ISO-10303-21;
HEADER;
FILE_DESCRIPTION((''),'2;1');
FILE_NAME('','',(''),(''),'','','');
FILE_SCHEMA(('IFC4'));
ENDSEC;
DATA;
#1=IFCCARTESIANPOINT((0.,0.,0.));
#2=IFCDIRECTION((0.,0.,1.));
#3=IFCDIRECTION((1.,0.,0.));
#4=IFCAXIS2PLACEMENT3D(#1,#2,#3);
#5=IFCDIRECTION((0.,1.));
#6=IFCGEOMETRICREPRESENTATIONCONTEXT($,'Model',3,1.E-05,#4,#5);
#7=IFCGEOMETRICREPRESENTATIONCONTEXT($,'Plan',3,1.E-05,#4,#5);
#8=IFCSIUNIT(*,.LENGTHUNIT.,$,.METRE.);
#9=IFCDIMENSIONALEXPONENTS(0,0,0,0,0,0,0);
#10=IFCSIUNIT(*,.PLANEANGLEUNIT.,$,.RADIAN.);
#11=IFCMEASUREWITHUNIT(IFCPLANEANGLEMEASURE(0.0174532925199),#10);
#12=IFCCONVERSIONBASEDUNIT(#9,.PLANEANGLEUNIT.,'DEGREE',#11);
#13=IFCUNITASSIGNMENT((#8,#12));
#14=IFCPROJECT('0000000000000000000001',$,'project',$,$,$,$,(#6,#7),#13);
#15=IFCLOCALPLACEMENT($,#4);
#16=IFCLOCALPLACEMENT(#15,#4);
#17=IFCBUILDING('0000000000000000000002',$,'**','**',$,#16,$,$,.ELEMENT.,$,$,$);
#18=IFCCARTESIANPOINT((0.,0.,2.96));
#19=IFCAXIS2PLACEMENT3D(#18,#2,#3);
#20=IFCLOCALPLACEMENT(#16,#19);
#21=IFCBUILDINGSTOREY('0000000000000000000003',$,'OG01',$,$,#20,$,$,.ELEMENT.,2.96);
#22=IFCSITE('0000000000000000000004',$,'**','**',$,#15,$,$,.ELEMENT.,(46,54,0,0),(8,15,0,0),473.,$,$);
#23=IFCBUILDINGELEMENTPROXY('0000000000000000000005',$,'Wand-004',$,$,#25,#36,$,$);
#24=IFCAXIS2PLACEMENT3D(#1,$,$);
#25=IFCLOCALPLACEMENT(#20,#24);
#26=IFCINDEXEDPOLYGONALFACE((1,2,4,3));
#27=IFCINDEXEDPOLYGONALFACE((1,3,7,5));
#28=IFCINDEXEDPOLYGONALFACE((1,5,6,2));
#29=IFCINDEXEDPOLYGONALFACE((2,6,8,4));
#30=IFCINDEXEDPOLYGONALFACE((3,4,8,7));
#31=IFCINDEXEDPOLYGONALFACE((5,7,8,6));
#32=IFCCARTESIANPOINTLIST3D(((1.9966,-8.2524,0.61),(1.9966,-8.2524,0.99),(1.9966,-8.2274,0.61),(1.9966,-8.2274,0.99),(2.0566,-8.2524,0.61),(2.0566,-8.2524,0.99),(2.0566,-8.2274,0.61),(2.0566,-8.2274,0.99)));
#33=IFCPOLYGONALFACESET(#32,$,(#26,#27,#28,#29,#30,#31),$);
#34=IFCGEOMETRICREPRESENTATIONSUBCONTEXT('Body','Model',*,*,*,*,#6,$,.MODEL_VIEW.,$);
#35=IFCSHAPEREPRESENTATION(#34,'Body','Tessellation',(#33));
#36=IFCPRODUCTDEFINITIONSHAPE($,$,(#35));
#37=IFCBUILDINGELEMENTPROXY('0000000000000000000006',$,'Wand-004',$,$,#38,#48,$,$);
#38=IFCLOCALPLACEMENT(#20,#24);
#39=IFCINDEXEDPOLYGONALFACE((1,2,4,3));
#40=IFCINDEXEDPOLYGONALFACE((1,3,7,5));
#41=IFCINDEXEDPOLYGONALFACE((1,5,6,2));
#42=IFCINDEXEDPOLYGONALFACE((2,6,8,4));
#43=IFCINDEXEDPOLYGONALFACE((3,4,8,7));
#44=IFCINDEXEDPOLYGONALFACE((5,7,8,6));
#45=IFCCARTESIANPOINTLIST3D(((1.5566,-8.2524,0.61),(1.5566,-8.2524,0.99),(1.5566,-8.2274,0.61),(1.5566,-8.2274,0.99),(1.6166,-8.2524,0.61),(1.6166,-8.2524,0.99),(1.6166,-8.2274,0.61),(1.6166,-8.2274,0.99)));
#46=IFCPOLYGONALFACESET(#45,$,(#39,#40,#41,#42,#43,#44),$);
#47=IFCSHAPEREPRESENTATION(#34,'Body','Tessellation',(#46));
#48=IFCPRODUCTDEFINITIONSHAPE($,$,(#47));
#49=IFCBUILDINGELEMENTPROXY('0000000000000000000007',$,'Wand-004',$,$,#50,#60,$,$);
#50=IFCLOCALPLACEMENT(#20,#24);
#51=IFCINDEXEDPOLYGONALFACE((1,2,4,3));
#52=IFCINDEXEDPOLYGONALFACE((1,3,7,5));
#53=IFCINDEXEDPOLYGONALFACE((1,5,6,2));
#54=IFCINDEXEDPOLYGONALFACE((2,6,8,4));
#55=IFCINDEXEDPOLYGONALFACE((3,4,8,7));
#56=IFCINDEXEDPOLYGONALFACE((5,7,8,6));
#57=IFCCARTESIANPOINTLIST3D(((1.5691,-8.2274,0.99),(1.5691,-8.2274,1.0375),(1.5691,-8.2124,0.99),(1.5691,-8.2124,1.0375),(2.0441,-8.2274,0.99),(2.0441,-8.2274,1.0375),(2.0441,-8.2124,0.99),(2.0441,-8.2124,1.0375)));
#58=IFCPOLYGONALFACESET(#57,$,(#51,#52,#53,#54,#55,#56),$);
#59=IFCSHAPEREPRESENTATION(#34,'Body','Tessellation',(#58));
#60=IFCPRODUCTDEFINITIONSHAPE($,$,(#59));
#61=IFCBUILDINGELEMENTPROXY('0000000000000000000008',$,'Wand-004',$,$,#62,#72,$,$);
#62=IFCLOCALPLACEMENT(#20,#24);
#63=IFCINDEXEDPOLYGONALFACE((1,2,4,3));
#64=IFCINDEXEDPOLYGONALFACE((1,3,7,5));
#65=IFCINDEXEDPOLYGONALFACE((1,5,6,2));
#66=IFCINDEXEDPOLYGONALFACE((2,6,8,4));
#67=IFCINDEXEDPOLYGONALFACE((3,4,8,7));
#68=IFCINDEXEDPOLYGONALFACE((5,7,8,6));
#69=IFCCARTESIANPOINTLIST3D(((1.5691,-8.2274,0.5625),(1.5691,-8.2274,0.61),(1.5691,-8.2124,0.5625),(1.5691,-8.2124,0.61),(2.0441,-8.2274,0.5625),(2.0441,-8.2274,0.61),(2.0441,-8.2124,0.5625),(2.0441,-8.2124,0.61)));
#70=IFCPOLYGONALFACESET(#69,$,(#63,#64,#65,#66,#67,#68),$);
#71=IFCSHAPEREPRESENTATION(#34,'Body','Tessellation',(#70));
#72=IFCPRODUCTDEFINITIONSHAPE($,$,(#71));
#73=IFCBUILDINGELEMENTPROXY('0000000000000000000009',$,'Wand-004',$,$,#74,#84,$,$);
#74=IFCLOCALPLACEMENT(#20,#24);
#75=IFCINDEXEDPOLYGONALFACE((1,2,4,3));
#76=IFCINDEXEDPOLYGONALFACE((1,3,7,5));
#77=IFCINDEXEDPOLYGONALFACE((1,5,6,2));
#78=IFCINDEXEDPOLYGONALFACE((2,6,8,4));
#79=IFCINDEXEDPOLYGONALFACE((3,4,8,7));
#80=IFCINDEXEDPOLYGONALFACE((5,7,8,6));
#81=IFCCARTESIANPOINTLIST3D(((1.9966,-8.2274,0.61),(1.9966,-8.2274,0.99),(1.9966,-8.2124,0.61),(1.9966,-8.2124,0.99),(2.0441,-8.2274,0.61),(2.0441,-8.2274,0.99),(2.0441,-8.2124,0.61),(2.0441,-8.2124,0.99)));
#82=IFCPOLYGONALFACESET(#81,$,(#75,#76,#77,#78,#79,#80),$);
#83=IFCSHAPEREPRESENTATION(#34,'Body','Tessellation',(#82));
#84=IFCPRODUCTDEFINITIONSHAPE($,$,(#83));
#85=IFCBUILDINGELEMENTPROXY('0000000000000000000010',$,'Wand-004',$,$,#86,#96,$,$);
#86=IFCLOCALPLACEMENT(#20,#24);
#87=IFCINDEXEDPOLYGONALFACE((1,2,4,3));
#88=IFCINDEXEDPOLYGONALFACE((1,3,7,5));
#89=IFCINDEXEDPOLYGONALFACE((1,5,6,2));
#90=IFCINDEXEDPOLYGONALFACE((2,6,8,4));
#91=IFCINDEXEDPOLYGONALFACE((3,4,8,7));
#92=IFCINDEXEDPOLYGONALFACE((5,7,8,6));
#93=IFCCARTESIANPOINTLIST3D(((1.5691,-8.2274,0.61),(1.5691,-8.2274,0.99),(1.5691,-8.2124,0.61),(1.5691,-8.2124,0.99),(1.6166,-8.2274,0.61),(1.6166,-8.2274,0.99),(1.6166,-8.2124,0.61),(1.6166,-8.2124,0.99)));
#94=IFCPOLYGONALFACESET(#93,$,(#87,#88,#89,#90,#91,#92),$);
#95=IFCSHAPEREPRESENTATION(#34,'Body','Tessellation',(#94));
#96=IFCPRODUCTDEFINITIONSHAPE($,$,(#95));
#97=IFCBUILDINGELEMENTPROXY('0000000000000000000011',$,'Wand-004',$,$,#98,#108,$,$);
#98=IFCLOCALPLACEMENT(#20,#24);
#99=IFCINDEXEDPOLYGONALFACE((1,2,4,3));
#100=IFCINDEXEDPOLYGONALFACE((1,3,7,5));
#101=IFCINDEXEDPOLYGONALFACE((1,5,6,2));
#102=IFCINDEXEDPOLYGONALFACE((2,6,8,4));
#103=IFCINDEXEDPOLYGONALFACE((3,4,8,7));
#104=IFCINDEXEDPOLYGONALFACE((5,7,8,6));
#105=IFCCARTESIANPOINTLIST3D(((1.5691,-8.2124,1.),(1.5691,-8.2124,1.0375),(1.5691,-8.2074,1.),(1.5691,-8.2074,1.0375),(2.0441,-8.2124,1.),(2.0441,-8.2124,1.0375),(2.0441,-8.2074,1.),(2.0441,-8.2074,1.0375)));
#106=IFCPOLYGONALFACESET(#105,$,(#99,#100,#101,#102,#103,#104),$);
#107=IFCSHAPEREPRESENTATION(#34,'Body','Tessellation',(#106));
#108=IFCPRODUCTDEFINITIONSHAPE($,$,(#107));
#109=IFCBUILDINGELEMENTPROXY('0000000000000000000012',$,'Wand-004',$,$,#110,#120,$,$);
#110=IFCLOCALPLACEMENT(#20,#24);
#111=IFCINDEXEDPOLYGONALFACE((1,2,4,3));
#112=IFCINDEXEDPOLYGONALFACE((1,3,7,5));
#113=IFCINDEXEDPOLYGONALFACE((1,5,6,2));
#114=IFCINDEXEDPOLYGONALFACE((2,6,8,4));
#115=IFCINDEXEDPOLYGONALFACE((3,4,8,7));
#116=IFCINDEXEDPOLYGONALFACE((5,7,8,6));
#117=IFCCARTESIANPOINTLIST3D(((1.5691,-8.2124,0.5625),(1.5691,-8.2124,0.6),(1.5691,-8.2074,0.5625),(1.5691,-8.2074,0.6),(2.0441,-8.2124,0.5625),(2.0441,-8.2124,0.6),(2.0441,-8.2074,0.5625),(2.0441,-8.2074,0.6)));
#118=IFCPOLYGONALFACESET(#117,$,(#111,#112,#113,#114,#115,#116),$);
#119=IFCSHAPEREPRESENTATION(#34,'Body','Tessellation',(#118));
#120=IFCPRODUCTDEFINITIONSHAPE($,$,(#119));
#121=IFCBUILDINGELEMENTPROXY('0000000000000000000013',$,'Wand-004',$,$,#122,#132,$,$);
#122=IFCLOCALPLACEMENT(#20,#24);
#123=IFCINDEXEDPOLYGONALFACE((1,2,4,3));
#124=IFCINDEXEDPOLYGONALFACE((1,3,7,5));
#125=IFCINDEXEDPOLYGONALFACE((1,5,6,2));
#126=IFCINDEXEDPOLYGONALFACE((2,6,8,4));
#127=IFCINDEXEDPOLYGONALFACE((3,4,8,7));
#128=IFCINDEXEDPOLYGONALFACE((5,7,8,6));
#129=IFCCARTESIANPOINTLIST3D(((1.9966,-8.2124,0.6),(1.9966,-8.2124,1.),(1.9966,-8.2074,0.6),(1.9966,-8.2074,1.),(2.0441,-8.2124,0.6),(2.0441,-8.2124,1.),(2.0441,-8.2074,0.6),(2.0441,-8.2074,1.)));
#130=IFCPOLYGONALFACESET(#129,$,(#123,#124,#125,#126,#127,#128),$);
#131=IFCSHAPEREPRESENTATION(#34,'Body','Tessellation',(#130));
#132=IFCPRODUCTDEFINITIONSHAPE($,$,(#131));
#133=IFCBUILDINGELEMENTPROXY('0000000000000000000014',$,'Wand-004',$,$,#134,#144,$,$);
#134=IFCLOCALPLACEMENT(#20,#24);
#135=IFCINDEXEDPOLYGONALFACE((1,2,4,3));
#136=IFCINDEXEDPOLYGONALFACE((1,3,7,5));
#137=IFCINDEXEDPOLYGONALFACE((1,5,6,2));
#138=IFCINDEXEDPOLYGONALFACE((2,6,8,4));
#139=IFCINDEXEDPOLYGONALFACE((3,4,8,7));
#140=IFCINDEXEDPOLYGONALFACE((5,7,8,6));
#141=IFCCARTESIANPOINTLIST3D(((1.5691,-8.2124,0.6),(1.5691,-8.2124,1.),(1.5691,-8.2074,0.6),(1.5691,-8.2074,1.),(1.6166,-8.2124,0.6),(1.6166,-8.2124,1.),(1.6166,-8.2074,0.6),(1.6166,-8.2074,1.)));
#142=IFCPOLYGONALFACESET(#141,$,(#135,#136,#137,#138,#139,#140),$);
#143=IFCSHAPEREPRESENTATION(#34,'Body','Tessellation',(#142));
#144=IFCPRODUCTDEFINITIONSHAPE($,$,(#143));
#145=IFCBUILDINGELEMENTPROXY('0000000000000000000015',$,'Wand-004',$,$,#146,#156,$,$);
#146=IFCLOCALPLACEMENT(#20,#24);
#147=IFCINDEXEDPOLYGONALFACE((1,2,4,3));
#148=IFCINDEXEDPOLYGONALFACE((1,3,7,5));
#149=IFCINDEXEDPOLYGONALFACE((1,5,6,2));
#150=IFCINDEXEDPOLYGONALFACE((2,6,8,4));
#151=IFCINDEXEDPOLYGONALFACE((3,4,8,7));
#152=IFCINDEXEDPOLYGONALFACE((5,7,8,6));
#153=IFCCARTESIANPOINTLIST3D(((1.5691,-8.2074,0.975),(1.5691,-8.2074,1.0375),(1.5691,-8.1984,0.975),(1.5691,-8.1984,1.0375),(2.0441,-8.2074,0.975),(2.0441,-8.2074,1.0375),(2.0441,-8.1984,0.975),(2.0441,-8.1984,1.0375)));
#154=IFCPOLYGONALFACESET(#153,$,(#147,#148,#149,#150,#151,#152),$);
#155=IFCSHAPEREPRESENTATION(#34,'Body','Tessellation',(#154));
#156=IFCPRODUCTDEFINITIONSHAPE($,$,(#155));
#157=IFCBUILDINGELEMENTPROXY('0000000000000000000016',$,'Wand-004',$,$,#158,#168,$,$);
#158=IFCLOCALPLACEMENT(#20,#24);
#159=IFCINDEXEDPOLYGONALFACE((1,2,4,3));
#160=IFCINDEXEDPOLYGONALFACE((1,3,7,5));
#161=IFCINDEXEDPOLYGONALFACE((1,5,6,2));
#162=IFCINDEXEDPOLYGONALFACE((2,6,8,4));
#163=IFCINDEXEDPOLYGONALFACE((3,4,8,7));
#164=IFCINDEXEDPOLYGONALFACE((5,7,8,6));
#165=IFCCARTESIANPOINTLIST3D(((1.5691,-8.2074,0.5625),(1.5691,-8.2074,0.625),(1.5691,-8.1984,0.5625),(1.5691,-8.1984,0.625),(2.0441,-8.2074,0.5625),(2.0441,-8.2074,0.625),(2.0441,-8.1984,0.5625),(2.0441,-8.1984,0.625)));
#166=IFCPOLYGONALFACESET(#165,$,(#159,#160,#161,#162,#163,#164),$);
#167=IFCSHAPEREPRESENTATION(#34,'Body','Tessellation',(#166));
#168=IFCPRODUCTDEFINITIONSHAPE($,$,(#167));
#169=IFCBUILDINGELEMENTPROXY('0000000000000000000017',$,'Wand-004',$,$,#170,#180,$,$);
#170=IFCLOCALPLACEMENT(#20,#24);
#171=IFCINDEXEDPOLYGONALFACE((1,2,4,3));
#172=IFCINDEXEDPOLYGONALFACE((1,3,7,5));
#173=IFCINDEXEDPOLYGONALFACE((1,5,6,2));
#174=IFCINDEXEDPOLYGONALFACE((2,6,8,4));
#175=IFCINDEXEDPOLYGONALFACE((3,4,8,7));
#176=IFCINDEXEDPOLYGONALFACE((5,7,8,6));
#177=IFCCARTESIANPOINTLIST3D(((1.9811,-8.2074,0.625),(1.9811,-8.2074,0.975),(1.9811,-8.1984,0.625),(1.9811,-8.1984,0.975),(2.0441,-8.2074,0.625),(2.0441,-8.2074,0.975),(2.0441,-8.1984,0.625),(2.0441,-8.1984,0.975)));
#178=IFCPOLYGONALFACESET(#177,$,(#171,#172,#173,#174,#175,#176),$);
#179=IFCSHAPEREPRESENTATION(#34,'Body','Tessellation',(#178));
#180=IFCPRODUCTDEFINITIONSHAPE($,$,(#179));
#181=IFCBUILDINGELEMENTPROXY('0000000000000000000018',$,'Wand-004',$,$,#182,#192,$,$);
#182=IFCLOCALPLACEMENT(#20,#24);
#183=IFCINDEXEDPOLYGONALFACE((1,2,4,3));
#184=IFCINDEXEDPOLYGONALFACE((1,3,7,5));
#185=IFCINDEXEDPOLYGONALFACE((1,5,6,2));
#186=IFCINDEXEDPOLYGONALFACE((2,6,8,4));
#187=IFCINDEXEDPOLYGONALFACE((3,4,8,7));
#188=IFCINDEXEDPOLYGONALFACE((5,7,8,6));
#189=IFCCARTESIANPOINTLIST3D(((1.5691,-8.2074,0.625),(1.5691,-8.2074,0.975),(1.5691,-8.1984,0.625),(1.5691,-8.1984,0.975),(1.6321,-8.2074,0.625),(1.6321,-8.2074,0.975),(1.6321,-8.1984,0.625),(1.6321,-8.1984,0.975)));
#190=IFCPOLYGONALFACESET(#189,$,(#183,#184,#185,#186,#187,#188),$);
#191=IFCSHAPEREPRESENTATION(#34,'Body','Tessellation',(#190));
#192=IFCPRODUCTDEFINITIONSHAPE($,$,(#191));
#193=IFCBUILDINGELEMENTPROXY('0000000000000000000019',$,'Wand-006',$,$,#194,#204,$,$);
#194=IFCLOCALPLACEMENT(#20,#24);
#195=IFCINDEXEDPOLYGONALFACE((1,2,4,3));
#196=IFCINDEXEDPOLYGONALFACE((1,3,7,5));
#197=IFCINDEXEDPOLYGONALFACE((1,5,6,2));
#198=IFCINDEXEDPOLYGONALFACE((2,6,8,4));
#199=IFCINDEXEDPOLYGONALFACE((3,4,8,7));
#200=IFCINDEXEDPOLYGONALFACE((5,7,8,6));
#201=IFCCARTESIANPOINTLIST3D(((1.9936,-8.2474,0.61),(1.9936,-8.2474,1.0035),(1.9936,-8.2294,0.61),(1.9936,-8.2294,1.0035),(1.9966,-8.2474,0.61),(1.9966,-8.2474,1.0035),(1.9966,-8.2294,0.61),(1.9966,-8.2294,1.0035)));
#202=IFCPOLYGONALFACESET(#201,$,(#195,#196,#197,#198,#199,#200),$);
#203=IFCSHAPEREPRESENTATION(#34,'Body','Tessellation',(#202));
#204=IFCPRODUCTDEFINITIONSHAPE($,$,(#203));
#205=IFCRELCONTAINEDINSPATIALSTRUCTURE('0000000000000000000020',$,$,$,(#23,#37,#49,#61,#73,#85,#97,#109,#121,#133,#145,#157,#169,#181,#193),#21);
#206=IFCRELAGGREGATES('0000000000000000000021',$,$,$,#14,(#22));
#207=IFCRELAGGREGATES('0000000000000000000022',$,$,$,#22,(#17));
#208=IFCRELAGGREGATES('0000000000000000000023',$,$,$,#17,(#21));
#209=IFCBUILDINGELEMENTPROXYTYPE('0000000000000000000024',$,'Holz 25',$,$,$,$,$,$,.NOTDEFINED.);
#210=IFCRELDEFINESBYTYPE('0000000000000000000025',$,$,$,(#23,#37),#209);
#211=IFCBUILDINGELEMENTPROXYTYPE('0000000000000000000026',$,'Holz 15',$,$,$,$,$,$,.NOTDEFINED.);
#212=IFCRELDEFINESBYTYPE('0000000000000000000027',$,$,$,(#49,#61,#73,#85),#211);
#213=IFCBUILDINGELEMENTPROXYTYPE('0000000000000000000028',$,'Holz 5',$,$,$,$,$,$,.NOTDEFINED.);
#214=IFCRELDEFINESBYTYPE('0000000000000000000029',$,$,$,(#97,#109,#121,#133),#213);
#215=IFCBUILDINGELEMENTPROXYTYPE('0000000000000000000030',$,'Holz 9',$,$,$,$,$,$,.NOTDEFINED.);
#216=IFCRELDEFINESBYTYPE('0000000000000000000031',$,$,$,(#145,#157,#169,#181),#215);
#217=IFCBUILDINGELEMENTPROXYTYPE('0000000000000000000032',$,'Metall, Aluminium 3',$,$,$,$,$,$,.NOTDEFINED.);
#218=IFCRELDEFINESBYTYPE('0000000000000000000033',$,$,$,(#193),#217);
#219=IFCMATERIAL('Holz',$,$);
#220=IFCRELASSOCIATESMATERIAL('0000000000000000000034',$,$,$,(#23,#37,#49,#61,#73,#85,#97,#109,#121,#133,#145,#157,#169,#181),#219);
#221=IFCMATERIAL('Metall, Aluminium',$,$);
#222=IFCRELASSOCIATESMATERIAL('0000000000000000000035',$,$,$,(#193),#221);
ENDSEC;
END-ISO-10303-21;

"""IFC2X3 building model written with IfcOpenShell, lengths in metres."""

from ifc_helpers import new_model, entity, si_unit, converted_unit, direction, frame, origin_with_axes, place, context, subcontext, project, spatial, polyline, outline, extrude, material, type_object, element, save


model = new_model("IFC2X3")

# Units and contexts
model_context = context("Model", 3, precision=1e-05, world=origin_with_axes(), true_north=direction((0.0, 1.0)))
plan_context = context("Plan", 3, precision=1e-05, world=origin_with_axes(), true_north=direction((0.0, 1.0)))
body_context = subcontext(model_context, "Body", "Model", "MODEL_VIEW")
ifc_project = project(units=[si_unit("LENGTHUNIT", "METRE"), converted_unit("PLANEANGLEUNIT", "DEGREE", entity("IfcPlaneAngleMeasure", 0.0174532925199), si_unit("PLANEANGLEUNIT", "RADIAN"), dimensions=[0, 0, 0, 0, 0, 0, 0])], contexts=[model_context, plan_context])

# Site, building, storey
site_placement = place(None, origin_with_axes())
site = spatial("IfcSite", under=ifc_project, at=site_placement, Name="**", Description="**", CompositionType="ELEMENT", RefLatitude=(46, 54, 0, 0), RefLongitude=(8, 15, 0, 0), RefElevation=473.0)
building_placement = place(site_placement, origin_with_axes())
building = spatial("IfcBuilding", under=site, at=building_placement, Name="**", Description="**", CompositionType="ELEMENT")
storey_placement = place(building_placement, frame((0.0, 0.0, 2.96), z_axis=(0.0, 0.0, 1.0), x_axis=(1.0, 0.0, 0.0)))
storey = spatial("IfcBuildingStorey", under=building, at=storey_placement, Name="OG01", CompositionType="ELEMENT", Elevation=2.96)

# Building element proxies
ifc_material_1 = material(Name="Holz")
building_element_proxy_type_1 = type_object("IfcBuildingElementProxyType", Name="Holz 25", PredefinedType="NOTDEFINED")
for number, where, z_axis, x_axis, name in (
    (1, (1.9966, -8.2524, 0.61), (0.0, 0.0, 1.0), (1.0, 0.0, 0.0), "Wand-004"),
    (2, (1.5566, -8.2524, 0.61), (0.0, 0.0, 1.0), (1.0, 0.0, 0.0), "Wand-004"),
):
    element("IfcBuildingElementProxy", number, at=place(storey_placement, frame(where, z_axis=z_axis, x_axis=x_axis)), inside=storey, type_object=building_element_proxy_type_1, material=ifc_material_1, Name=name, context=body_context, shape_type="SweptSolid", body=[
        extrude(outline(polyline([(0.0, 0.0), (0.06, 0.0), (0.06, 0.025), (0.0, 0.025), (0.0, 0.0)])), origin_with_axes(), (0.0, 0.0, 1.0), 0.38),
    ])
building_element_proxy_type_2 = type_object("IfcBuildingElementProxyType", Name="Holz 15", PredefinedType="NOTDEFINED")
for number, where, z_axis, x_axis, name in (
    (3, (2.0441, -8.2124, 0.99), (0.0, 0.0, 1.0), (-1.0, 0.0, 0.0), "Wand-004"),
    (4, (2.0441, -8.2124, 0.5625), (0.0, 0.0, 1.0), (-1.0, 0.0, 0.0), "Wand-004"),
):
    element("IfcBuildingElementProxy", number, at=place(storey_placement, frame(where, z_axis=z_axis, x_axis=x_axis)), inside=storey, type_object=building_element_proxy_type_2, material=ifc_material_1, Name=name, context=body_context, shape_type="SweptSolid", body=[
        extrude(outline(polyline([(0.0, 0.0), (0.475, 0.0), (0.475, 0.015), (0.0, 0.015), (0.0, 0.0)])), origin_with_axes(), (0.0, 0.0, 1.0), 0.0475),
    ])
for number, where, z_axis, x_axis, name in (
    (5, (1.9966, -8.2274, 0.61), (0.0, 0.0, 1.0), (1.0, 0.0, 0.0), "Wand-004"),
    (6, (1.5691, -8.2274, 0.61), (0.0, 0.0, 1.0), (1.0, 0.0, 0.0), "Wand-004"),
):
    element("IfcBuildingElementProxy", number, at=place(storey_placement, frame(where, z_axis=z_axis, x_axis=x_axis)), inside=storey, type_object=building_element_proxy_type_2, material=ifc_material_1, Name=name, context=body_context, shape_type="SweptSolid", body=[
        extrude(outline(polyline([(0.0, 0.0), (0.0475, 0.0), (0.0475, 0.015), (0.0, 0.015), (0.0, 0.0)])), origin_with_axes(), (0.0, 0.0, 1.0), 0.38),
    ])
building_element_proxy_type_3 = type_object("IfcBuildingElementProxyType", Name="Holz 5", PredefinedType="NOTDEFINED")
for number, where, z_axis, x_axis, name in (
    (7, (2.0441, -8.2124, 1.0), (0.0, 0.0, 1.0), (-1.0, 0.0, 0.0), "Wand-004"),
    (8, (2.0441, -8.2124, 0.5625), (0.0, 0.0, 1.0), (-1.0, 0.0, 0.0), "Wand-004"),
):
    element("IfcBuildingElementProxy", number, at=place(storey_placement, frame(where, z_axis=z_axis, x_axis=x_axis)), inside=storey, type_object=building_element_proxy_type_3, material=ifc_material_1, Name=name, context=body_context, shape_type="SweptSolid", body=[
        extrude(outline(polyline([(0.0, -0.005), (0.475, -0.005), (0.475, 0.0), (0.0, 0.0), (0.0, -0.005)])), origin_with_axes(), (0.0, 0.0, 1.0), 0.0375),
    ])
for number, where, z_axis, x_axis, name in (
    (9, (1.9966, -8.2124, 0.6), (0.0, 0.0, 1.0), (1.0, 0.0, 0.0), "Wand-004"),
    (10, (1.5691, -8.2124, 0.6), (0.0, 0.0, 1.0), (1.0, 0.0, 0.0), "Wand-004"),
):
    element("IfcBuildingElementProxy", number, at=place(storey_placement, frame(where, z_axis=z_axis, x_axis=x_axis)), inside=storey, type_object=building_element_proxy_type_3, material=ifc_material_1, Name=name, context=body_context, shape_type="SweptSolid", body=[
        extrude(outline(polyline([(0.0, 0.0), (0.0475, 0.0), (0.0475, 0.005), (0.0, 0.005), (0.0, 0.0)])), origin_with_axes(), (0.0, 0.0, 1.0), 0.4),
    ])
building_element_proxy_type_4 = type_object("IfcBuildingElementProxyType", Name="Holz 9", PredefinedType="NOTDEFINED")
for number, where, z_axis, x_axis, name in (
    (11, (2.0441, -8.2074, 0.975), (0.0, 0.0, 1.0), (-1.0, 0.0, 0.0), "Wand-004"),
    (12, (2.0441, -8.2074, 0.5625), (0.0, 0.0, 1.0), (-1.0, 0.0, 0.0), "Wand-004"),
):
    element("IfcBuildingElementProxy", number, at=place(storey_placement, frame(where, z_axis=z_axis, x_axis=x_axis)), inside=storey, type_object=building_element_proxy_type_4, material=ifc_material_1, Name=name, context=body_context, shape_type="SweptSolid", body=[
        extrude(outline(polyline([(0.0, -0.009), (0.475, -0.009), (0.475, 0.0), (0.0, 0.0), (0.0, -0.009)])), origin_with_axes(), (0.0, 0.0, 1.0), 0.0625),
    ])
for number, where, z_axis, x_axis, name in (
    (13, (1.9811, -8.2074, 0.625), (0.0, 0.0, 1.0), (1.0, 0.0, 0.0), "Wand-004"),
    (14, (1.5691, -8.2074, 0.625), (0.0, 0.0, 1.0), (1.0, 0.0, 0.0), "Wand-004"),
):
    element("IfcBuildingElementProxy", number, at=place(storey_placement, frame(where, z_axis=z_axis, x_axis=x_axis)), inside=storey, type_object=building_element_proxy_type_4, material=ifc_material_1, Name=name, context=body_context, shape_type="SweptSolid", body=[
        extrude(outline(polyline([(0.0, 0.0), (0.063, 0.0), (0.063, 0.009), (0.0, 0.009), (0.0, 0.0)])), origin_with_axes(), (0.0, 0.0, 1.0), 0.35),
    ])
ifc_material_2 = material(Name="Metall, Aluminium")
building_element_proxy_type_5 = type_object("IfcBuildingElementProxyType", Name="Metall, Aluminium 3", PredefinedType="NOTDEFINED")
proxy_1_placement = place(storey_placement, frame((1.9966, -8.2294, 0.61), z_axis=(0.0, 0.0, 1.0), x_axis=(0.0, -1.0, 0.0)))
element("IfcBuildingElementProxy", 15, at=proxy_1_placement, inside=storey, type_object=building_element_proxy_type_5, material=ifc_material_2, Name="Wand-006", context=body_context, shape_type="SweptSolid", body=[
    extrude(outline(polyline([(0.0, -0.003), (0.018, -0.003), (0.018, 0.0), (0.0, 0.0), (0.0, -0.003)])), origin_with_axes(), (0.0, 0.0, 1.0), 0.3935),
])

save(model, "model.ifc")
